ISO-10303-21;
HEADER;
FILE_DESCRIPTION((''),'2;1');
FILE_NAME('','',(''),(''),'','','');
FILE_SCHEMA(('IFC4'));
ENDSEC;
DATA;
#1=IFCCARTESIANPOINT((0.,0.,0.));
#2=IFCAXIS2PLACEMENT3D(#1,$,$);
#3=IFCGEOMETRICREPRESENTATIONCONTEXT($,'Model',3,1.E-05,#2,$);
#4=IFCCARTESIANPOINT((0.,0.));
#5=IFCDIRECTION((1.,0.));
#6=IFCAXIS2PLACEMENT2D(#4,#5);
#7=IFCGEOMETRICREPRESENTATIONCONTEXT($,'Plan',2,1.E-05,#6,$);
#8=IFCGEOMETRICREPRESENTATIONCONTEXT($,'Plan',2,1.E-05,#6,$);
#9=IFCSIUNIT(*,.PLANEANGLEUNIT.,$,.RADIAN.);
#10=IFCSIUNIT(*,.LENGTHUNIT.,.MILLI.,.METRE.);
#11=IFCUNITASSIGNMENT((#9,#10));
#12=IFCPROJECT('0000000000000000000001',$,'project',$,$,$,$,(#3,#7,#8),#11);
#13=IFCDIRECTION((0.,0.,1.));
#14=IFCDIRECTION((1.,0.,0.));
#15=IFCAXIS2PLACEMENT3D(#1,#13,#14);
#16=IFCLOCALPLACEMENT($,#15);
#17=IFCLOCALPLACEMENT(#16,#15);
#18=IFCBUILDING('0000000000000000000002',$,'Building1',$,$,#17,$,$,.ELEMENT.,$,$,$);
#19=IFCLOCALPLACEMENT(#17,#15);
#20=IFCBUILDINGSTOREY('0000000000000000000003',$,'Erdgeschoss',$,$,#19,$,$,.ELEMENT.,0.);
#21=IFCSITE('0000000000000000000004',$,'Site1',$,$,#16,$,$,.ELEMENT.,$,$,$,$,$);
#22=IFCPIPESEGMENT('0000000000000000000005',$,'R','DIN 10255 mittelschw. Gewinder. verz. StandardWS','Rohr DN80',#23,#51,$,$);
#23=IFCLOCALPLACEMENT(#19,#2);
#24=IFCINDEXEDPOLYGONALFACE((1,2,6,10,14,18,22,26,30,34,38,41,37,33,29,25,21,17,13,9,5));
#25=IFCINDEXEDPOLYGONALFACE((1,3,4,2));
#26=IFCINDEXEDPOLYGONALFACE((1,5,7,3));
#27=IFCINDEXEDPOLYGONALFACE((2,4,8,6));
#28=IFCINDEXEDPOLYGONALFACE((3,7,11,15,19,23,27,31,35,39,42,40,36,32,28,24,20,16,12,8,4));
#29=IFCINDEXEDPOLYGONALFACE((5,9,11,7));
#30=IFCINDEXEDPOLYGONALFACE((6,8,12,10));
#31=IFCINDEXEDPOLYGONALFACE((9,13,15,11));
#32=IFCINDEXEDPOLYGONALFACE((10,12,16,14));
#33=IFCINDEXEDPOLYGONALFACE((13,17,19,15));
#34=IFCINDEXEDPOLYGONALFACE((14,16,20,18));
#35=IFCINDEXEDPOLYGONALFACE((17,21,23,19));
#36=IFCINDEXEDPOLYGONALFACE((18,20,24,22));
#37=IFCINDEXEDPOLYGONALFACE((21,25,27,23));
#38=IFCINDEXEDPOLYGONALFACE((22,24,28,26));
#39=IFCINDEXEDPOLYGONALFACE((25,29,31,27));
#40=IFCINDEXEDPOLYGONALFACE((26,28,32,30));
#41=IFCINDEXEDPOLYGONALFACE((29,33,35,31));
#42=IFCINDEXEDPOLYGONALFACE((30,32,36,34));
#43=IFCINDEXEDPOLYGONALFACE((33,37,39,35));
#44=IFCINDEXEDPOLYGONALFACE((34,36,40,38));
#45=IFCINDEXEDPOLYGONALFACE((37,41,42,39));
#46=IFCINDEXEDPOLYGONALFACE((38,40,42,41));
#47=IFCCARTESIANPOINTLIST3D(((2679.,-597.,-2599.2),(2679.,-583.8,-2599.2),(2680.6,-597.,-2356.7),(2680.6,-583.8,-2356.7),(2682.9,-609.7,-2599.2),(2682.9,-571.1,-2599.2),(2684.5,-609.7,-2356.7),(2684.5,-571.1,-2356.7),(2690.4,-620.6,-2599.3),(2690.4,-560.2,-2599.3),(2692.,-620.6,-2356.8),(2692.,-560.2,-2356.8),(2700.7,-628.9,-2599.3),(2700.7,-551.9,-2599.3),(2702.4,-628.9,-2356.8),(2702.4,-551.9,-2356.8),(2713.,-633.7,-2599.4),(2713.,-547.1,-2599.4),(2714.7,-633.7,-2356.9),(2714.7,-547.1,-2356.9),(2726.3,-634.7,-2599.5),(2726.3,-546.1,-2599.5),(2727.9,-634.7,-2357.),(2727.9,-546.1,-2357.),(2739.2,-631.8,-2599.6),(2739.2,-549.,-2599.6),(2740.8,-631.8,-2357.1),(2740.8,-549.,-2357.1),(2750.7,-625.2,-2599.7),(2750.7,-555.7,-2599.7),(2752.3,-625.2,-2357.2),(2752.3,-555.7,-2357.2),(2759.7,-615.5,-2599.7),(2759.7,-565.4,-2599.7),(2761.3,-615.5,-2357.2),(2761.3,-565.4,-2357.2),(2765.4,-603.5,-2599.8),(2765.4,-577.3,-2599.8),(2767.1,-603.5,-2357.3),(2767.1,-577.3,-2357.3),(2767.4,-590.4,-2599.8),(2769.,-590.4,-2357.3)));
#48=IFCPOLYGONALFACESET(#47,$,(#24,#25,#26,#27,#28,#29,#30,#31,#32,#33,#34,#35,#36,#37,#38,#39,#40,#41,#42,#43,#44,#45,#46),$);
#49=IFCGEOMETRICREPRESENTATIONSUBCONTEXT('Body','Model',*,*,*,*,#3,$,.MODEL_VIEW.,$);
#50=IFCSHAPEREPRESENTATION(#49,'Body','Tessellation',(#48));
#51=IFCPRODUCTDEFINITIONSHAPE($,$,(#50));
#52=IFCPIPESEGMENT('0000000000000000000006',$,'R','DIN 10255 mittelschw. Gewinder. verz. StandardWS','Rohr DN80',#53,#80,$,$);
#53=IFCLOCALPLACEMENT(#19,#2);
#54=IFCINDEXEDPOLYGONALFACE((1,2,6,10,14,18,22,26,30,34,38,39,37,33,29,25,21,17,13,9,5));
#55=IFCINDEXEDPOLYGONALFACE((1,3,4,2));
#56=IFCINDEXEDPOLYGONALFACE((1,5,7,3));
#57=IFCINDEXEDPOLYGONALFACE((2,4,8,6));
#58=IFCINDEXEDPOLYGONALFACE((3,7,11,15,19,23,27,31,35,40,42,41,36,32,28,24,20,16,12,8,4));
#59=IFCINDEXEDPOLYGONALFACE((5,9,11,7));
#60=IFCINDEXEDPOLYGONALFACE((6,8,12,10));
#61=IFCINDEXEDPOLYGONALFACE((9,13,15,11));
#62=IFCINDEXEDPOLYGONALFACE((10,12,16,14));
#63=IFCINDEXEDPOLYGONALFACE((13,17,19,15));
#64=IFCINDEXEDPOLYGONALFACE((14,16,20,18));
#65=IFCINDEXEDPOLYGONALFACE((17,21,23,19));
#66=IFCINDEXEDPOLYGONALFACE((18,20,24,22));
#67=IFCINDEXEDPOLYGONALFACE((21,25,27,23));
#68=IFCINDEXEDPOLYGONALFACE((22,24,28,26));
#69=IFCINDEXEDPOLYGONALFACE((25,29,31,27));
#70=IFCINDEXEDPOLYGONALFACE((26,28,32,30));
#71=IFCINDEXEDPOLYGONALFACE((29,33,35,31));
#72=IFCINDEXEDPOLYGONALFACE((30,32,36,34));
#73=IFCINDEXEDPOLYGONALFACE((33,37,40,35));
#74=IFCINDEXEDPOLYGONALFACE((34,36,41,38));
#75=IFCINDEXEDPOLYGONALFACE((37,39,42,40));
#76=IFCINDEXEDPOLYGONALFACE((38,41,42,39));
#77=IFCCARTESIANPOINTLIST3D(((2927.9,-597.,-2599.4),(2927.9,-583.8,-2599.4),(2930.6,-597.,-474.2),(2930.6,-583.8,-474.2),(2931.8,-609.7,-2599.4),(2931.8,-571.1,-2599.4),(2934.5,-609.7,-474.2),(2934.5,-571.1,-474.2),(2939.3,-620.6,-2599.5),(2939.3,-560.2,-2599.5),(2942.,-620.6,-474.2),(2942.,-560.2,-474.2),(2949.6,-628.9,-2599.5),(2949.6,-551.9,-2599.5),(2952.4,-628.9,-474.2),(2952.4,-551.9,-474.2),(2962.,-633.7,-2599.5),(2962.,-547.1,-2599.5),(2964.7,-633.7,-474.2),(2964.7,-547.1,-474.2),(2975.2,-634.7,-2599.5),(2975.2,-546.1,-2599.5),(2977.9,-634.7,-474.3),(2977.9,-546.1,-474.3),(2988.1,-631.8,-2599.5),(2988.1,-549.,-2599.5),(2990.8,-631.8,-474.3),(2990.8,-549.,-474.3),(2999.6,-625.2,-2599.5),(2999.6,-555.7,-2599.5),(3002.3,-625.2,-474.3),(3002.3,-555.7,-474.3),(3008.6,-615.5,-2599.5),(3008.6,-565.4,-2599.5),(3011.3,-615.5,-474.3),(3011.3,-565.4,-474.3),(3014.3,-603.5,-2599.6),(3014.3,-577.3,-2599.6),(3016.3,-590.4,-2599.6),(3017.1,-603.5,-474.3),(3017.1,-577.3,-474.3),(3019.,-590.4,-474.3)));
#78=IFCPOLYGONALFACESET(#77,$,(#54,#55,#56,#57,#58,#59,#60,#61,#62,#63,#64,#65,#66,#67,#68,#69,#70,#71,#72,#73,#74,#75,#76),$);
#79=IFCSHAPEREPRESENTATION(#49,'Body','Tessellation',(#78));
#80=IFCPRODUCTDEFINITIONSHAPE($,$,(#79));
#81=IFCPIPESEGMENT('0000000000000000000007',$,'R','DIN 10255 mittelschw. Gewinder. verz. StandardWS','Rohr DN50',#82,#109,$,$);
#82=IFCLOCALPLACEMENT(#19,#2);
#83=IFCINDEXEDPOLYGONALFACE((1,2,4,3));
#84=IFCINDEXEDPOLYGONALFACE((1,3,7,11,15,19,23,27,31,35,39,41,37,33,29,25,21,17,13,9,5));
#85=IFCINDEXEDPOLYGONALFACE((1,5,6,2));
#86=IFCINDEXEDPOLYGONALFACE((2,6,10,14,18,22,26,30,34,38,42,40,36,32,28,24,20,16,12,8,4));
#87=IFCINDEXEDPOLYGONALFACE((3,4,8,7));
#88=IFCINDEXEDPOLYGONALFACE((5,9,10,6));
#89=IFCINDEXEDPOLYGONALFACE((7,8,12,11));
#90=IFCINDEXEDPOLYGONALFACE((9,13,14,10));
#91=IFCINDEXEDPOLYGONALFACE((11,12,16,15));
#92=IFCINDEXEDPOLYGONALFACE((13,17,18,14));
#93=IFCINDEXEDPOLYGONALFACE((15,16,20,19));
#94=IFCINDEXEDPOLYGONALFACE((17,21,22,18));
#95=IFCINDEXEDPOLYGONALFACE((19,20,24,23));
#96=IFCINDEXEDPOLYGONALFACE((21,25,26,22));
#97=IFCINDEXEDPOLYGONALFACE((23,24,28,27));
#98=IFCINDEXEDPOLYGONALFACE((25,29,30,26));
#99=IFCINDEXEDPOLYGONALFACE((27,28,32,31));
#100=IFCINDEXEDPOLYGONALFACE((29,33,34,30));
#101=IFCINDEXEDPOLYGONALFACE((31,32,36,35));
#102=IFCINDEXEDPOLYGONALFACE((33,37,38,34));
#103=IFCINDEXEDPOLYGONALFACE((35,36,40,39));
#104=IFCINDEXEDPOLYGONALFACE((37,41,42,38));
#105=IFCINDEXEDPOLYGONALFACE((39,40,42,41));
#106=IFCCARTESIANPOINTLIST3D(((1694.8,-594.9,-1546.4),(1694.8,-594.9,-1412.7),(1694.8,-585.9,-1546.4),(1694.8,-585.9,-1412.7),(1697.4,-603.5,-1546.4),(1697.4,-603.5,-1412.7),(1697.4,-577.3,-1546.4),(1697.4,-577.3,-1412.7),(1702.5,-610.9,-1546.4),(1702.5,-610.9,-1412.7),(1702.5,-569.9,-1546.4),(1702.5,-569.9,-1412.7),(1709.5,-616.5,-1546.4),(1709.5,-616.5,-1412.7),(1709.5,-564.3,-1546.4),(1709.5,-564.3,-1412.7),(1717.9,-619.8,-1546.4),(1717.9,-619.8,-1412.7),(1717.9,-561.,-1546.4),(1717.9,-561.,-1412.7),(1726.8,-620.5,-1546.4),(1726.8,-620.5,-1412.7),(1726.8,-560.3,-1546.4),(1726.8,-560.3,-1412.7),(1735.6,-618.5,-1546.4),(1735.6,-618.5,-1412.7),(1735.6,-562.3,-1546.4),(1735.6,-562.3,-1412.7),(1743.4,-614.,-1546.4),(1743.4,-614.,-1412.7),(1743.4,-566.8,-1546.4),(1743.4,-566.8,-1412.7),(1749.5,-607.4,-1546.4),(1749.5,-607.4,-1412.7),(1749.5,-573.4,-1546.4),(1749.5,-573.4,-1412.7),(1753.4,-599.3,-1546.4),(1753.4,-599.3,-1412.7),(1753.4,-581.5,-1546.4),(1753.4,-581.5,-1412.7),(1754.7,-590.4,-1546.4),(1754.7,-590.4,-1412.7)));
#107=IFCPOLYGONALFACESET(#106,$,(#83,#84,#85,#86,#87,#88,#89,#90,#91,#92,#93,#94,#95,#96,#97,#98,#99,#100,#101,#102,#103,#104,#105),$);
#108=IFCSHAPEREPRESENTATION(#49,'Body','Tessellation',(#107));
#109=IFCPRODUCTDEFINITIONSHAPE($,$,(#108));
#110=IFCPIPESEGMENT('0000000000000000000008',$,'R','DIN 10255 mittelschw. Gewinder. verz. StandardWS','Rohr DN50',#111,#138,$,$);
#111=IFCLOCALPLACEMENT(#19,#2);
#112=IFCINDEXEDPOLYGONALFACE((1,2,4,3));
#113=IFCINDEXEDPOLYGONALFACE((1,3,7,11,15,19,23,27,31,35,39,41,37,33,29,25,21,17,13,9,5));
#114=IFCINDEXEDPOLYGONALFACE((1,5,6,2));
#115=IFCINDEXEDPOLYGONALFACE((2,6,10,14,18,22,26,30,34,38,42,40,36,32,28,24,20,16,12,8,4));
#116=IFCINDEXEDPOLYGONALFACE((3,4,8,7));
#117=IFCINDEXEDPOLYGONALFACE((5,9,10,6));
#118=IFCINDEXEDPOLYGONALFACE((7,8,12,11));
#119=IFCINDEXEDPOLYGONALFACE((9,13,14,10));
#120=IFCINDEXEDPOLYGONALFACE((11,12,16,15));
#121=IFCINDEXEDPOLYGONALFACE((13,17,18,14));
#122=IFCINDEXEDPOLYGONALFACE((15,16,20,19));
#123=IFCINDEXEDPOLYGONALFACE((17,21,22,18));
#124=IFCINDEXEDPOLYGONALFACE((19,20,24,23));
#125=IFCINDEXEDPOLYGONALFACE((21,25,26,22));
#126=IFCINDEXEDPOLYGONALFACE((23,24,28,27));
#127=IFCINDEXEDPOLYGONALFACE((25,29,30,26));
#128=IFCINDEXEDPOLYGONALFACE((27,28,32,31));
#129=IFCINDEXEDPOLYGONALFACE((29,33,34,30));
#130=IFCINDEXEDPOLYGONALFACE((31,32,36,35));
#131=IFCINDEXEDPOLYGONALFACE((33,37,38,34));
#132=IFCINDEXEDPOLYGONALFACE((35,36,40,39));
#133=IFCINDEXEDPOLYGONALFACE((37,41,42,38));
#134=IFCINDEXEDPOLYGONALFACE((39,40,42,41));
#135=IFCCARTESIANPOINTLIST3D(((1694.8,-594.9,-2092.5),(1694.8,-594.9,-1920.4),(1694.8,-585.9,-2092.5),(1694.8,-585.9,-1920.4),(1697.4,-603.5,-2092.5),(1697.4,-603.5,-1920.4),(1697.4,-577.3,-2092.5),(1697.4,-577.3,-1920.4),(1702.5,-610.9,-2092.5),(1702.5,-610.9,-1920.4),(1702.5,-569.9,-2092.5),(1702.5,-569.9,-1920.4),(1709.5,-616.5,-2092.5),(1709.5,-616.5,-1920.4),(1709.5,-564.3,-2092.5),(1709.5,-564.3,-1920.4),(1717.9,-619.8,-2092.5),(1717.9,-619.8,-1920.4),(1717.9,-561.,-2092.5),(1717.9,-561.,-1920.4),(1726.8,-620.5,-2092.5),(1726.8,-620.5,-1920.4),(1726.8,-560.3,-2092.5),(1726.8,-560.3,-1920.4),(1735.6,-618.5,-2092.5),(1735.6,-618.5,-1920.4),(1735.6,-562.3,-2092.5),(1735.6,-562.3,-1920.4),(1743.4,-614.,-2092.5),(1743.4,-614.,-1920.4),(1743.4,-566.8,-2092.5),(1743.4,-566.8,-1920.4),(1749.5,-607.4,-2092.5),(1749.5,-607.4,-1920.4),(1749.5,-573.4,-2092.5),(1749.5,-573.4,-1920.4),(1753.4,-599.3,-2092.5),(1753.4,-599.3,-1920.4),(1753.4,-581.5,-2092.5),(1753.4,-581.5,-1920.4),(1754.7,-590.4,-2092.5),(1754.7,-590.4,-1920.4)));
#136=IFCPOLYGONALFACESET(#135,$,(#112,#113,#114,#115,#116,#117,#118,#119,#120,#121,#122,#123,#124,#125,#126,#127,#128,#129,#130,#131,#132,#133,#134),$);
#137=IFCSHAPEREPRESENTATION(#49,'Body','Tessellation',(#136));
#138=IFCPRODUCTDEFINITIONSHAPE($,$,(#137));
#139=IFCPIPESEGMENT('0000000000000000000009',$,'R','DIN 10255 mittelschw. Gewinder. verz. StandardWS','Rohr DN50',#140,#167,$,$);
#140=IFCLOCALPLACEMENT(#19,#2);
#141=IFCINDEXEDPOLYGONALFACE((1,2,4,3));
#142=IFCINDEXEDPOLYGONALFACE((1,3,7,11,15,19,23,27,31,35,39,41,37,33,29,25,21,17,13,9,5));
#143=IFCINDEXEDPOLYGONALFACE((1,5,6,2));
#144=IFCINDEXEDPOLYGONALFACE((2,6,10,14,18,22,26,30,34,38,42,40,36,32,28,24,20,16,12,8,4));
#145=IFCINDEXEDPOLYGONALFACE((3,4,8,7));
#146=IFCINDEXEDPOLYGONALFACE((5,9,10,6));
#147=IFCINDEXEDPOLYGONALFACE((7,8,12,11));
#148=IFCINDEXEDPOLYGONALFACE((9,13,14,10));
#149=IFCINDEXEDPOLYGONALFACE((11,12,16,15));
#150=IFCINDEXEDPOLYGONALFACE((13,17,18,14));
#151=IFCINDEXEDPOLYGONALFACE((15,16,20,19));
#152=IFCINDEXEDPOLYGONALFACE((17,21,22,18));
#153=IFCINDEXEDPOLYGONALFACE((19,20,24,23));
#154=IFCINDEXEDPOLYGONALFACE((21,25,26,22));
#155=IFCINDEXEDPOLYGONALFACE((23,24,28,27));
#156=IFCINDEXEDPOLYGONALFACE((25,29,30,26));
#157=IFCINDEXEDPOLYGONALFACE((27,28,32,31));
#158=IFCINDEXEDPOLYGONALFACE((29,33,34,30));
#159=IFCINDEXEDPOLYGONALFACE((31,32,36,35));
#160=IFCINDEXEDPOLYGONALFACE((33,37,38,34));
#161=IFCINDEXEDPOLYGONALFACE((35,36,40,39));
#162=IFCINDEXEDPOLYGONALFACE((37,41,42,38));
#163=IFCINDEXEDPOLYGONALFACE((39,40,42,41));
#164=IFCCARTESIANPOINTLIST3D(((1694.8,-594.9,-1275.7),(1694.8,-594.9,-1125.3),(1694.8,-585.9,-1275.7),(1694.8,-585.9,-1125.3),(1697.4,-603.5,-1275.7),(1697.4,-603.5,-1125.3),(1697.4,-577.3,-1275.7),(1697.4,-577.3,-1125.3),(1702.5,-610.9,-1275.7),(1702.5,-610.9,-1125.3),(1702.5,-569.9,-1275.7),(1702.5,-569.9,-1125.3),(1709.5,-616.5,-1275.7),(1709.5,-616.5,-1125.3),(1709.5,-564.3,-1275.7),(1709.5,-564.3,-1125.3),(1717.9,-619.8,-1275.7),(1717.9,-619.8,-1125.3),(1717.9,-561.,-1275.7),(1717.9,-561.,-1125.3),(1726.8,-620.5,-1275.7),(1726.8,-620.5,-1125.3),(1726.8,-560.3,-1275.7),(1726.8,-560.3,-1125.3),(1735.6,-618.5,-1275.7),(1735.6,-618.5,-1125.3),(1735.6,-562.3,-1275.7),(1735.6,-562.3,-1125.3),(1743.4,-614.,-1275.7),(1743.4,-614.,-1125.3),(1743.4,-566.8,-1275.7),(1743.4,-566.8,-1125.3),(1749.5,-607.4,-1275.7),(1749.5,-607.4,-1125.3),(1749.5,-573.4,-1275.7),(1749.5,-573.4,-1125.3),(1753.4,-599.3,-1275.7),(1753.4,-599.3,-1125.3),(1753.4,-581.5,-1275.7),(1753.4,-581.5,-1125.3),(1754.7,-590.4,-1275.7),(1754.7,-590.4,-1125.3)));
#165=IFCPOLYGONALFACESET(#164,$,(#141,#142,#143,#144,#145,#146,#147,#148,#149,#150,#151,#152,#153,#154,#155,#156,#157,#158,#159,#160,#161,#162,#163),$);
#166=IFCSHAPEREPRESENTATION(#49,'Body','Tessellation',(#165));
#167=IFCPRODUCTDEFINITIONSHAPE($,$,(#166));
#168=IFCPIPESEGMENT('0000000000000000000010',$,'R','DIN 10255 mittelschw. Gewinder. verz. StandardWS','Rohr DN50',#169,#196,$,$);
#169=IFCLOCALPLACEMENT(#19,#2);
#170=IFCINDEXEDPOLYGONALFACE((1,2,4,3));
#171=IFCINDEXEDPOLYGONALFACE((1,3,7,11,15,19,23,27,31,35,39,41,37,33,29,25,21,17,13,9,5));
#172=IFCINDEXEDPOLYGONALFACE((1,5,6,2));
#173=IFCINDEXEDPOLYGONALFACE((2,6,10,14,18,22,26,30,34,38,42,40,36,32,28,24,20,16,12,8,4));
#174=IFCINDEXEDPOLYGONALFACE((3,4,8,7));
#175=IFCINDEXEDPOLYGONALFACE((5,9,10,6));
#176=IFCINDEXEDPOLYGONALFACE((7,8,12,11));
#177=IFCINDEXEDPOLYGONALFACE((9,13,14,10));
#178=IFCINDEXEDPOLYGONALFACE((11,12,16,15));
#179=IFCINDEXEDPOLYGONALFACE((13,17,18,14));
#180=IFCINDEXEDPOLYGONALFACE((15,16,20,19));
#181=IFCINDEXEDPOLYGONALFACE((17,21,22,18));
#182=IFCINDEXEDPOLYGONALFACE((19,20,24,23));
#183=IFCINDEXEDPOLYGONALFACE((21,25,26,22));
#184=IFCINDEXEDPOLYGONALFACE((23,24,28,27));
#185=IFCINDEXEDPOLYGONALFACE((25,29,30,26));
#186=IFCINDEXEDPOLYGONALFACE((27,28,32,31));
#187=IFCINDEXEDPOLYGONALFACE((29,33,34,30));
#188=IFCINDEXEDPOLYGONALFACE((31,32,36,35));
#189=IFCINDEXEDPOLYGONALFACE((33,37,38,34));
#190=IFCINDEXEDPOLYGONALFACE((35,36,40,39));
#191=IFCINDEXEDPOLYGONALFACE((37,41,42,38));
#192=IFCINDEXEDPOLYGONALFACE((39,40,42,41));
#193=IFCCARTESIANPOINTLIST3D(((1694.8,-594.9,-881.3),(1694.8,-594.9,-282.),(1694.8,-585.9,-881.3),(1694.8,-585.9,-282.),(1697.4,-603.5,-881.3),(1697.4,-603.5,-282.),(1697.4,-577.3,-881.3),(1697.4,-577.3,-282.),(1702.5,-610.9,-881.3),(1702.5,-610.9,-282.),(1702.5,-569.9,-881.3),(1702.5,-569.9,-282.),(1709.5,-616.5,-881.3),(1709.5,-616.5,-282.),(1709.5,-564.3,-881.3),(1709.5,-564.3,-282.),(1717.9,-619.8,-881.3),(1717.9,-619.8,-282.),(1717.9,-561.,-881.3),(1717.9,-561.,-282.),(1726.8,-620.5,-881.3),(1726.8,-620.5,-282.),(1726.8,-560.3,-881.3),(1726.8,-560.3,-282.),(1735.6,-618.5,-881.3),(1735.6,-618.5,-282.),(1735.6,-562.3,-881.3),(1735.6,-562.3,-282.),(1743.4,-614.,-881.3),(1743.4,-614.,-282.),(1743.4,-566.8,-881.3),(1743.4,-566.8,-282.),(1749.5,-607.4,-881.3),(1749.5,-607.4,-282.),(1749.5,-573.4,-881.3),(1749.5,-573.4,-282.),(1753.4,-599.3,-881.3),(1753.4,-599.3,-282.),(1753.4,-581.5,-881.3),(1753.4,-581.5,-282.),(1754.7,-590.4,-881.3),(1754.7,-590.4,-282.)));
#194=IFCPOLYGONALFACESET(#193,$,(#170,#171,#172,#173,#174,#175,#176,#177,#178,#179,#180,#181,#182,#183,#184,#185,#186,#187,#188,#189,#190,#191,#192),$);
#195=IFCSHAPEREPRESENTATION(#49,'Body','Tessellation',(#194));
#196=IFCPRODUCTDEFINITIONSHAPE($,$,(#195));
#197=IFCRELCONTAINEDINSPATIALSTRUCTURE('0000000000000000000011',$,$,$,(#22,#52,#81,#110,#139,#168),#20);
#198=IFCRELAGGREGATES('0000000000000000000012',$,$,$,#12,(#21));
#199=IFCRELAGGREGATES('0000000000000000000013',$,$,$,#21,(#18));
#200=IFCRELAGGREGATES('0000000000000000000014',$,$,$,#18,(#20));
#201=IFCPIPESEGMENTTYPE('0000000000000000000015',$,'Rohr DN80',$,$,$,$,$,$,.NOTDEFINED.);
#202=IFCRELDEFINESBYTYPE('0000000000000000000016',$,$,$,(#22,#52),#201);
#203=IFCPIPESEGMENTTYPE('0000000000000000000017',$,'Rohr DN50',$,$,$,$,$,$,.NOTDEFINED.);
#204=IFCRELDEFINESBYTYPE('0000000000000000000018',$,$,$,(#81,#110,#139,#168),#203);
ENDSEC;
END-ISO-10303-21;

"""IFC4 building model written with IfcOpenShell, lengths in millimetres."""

from ifc_helpers import new_model, si_unit, frame, origin, origin_with_axes, origin_2d_with_axis, place, context, subcontext, project, spatial, circle, extrude, type_object, element, save


model = new_model("IFC4")

# Units and contexts
model_context = context("Model", 3, precision=1e-05, world=origin())
plan_context_1 = context("Plan", 2, precision=1e-05, world=origin_2d_with_axis())
plan_context_2 = context("Plan", 2, precision=1e-05, world=origin_2d_with_axis())
body_context = subcontext(model_context, "Body", "Model", "MODEL_VIEW")
ifc_project = project(units=[si_unit("PLANEANGLEUNIT", "RADIAN"), si_unit("LENGTHUNIT", "METRE", prefix="MILLI")], contexts=[model_context, plan_context_1, plan_context_2])

# Site, building, storey
site_placement = place(None, origin_with_axes())
site = spatial("IfcSite", under=ifc_project, at=site_placement, Name="Site1", CompositionType="ELEMENT")
building_placement = place(site_placement, origin_with_axes())
building = spatial("IfcBuilding", under=site, at=building_placement, Name="Building1", CompositionType="ELEMENT")
storey_placement = place(building_placement, origin_with_axes())
storey = spatial("IfcBuildingStorey", under=building, at=storey_placement, Name="Erdgeschoss", CompositionType="ELEMENT", Elevation=0.0)

# Pipe segments
pipe_segment_type_1 = type_object("IfcPipeSegmentType", Name="Rohr DN80", PredefinedType="NOTDEFINED")
pipe_segment_1_placement = place(storey_placement, frame((2723.8, -590.6, -2478.2), z_axis=(0.0, 0.0, 1.0), x_axis=(1.0, 0.0, 0.0)))
element("IfcPipeSegment", 1, at=pipe_segment_1_placement, inside=storey, type_object=pipe_segment_type_1, Name="R", Description="DIN 10255 mittelschw. Gewinder. verz. StandardWS", ObjectType="Rohr DN80", context=body_context, shape_type="SolidModel", body=[
    extrude(circle(Radius=44.5, at=origin_2d_with_axis()), frame((-0.8, 0.1, -121.3), z_axis=(0.006764, 0.0, 0.999977), x_axis=(1.0, 0.0, 0.0)), (0.0, 0.0, 1.0), 242.5),
])
pipe_segment_2_placement = place(storey_placement, frame((2973.2, -590.6, -1536.9), z_axis=(0.0, 0.0, 1.0), x_axis=(1.0, 0.0, 0.0)))
element("IfcPipeSegment", 2, at=pipe_segment_2_placement, inside=storey, type_object=pipe_segment_type_1, Name="R", Description="DIN 10255 mittelschw. Gewinder. verz. StandardWS", ObjectType="Rohr DN80", context=body_context, shape_type="SolidModel", body=[
    extrude(circle(Radius=44.5, at=origin_2d_with_axis()), frame((-1.4, 0.1, -1062.6), z_axis=(0.001276, 0.0, 0.999999), x_axis=(1.0, 0.0, 0.0)), (0.0, 0.0, 1.0), 2125.3),
])
pipe_segment_type_2 = type_object("IfcPipeSegmentType", Name="Rohr DN50", PredefinedType="NOTDEFINED")
pipe_segment_3_placement = place(storey_placement, frame((1724.6, -590.6, -1479.6), z_axis=(0.0, 0.0, 1.0), x_axis=(1.0, 0.0, 0.0)))
element("IfcPipeSegment", 3, at=pipe_segment_3_placement, inside=storey, type_object=pipe_segment_type_2, Name="R", Description="DIN 10255 mittelschw. Gewinder. verz. StandardWS", ObjectType="Rohr DN50", context=body_context, shape_type="SolidModel", body=[
    extrude(circle(Radius=30.1, at=origin_2d_with_axis()), frame((0.0, 0.1, -66.8), z_axis=(0.0, 0.0, 1.0), x_axis=(1.0, 0.0, 0.0)), (0.0, 0.0, 1.0), 133.7),
])
pipe_segment_4_placement = place(storey_placement, frame((1724.6, -590.6, -2006.4), z_axis=(0.0, 0.0, 1.0), x_axis=(1.0, 0.0, 0.0)))
element("IfcPipeSegment", 4, at=pipe_segment_4_placement, inside=storey, type_object=pipe_segment_type_2, Name="R", Description="DIN 10255 mittelschw. Gewinder. verz. StandardWS", ObjectType="Rohr DN50", context=body_context, shape_type="SolidModel", body=[
    extrude(circle(Radius=30.1, at=origin_2d_with_axis()), frame((0.0, 0.1, -86.1), z_axis=(0.0, 0.0, 1.0), x_axis=(1.0, 0.0, 0.0)), (0.0, 0.0, 1.0), 172.1),
])
pipe_segment_5_placement = place(storey_placement, frame((1724.6, -590.6, -1200.5), z_axis=(0.0, 0.0, 1.0), x_axis=(1.0, 0.0, 0.0)))
element("IfcPipeSegment", 5, at=pipe_segment_5_placement, inside=storey, type_object=pipe_segment_type_2, Name="R", Description="DIN 10255 mittelschw. Gewinder. verz. StandardWS", ObjectType="Rohr DN50", context=body_context, shape_type="SolidModel", body=[
    extrude(circle(Radius=30.1, at=origin_2d_with_axis()), frame((0.0, 0.1, -75.2), z_axis=(0.0, 0.0, 1.0), x_axis=(1.0, 0.0, 0.0)), (0.0, 0.0, 1.0), 150.5),
])
pipe_segment_6_placement = place(storey_placement, frame((1724.6, -590.6, -581.6), z_axis=(0.0, 0.0, 1.0), x_axis=(1.0, 0.0, 0.0)))
element("IfcPipeSegment", 6, at=pipe_segment_6_placement, inside=storey, type_object=pipe_segment_type_2, Name="R", Description="DIN 10255 mittelschw. Gewinder. verz. StandardWS", ObjectType="Rohr DN50", context=body_context, shape_type="SolidModel", body=[
    extrude(circle(Radius=30.1, at=origin_2d_with_axis()), frame((0.0, 0.1, -299.6), z_axis=(0.0, 0.0, 1.0), x_axis=(1.0, 0.0, 0.0)), (0.0, 0.0, 1.0), 599.3),
])

save(model, "model.ifc")
